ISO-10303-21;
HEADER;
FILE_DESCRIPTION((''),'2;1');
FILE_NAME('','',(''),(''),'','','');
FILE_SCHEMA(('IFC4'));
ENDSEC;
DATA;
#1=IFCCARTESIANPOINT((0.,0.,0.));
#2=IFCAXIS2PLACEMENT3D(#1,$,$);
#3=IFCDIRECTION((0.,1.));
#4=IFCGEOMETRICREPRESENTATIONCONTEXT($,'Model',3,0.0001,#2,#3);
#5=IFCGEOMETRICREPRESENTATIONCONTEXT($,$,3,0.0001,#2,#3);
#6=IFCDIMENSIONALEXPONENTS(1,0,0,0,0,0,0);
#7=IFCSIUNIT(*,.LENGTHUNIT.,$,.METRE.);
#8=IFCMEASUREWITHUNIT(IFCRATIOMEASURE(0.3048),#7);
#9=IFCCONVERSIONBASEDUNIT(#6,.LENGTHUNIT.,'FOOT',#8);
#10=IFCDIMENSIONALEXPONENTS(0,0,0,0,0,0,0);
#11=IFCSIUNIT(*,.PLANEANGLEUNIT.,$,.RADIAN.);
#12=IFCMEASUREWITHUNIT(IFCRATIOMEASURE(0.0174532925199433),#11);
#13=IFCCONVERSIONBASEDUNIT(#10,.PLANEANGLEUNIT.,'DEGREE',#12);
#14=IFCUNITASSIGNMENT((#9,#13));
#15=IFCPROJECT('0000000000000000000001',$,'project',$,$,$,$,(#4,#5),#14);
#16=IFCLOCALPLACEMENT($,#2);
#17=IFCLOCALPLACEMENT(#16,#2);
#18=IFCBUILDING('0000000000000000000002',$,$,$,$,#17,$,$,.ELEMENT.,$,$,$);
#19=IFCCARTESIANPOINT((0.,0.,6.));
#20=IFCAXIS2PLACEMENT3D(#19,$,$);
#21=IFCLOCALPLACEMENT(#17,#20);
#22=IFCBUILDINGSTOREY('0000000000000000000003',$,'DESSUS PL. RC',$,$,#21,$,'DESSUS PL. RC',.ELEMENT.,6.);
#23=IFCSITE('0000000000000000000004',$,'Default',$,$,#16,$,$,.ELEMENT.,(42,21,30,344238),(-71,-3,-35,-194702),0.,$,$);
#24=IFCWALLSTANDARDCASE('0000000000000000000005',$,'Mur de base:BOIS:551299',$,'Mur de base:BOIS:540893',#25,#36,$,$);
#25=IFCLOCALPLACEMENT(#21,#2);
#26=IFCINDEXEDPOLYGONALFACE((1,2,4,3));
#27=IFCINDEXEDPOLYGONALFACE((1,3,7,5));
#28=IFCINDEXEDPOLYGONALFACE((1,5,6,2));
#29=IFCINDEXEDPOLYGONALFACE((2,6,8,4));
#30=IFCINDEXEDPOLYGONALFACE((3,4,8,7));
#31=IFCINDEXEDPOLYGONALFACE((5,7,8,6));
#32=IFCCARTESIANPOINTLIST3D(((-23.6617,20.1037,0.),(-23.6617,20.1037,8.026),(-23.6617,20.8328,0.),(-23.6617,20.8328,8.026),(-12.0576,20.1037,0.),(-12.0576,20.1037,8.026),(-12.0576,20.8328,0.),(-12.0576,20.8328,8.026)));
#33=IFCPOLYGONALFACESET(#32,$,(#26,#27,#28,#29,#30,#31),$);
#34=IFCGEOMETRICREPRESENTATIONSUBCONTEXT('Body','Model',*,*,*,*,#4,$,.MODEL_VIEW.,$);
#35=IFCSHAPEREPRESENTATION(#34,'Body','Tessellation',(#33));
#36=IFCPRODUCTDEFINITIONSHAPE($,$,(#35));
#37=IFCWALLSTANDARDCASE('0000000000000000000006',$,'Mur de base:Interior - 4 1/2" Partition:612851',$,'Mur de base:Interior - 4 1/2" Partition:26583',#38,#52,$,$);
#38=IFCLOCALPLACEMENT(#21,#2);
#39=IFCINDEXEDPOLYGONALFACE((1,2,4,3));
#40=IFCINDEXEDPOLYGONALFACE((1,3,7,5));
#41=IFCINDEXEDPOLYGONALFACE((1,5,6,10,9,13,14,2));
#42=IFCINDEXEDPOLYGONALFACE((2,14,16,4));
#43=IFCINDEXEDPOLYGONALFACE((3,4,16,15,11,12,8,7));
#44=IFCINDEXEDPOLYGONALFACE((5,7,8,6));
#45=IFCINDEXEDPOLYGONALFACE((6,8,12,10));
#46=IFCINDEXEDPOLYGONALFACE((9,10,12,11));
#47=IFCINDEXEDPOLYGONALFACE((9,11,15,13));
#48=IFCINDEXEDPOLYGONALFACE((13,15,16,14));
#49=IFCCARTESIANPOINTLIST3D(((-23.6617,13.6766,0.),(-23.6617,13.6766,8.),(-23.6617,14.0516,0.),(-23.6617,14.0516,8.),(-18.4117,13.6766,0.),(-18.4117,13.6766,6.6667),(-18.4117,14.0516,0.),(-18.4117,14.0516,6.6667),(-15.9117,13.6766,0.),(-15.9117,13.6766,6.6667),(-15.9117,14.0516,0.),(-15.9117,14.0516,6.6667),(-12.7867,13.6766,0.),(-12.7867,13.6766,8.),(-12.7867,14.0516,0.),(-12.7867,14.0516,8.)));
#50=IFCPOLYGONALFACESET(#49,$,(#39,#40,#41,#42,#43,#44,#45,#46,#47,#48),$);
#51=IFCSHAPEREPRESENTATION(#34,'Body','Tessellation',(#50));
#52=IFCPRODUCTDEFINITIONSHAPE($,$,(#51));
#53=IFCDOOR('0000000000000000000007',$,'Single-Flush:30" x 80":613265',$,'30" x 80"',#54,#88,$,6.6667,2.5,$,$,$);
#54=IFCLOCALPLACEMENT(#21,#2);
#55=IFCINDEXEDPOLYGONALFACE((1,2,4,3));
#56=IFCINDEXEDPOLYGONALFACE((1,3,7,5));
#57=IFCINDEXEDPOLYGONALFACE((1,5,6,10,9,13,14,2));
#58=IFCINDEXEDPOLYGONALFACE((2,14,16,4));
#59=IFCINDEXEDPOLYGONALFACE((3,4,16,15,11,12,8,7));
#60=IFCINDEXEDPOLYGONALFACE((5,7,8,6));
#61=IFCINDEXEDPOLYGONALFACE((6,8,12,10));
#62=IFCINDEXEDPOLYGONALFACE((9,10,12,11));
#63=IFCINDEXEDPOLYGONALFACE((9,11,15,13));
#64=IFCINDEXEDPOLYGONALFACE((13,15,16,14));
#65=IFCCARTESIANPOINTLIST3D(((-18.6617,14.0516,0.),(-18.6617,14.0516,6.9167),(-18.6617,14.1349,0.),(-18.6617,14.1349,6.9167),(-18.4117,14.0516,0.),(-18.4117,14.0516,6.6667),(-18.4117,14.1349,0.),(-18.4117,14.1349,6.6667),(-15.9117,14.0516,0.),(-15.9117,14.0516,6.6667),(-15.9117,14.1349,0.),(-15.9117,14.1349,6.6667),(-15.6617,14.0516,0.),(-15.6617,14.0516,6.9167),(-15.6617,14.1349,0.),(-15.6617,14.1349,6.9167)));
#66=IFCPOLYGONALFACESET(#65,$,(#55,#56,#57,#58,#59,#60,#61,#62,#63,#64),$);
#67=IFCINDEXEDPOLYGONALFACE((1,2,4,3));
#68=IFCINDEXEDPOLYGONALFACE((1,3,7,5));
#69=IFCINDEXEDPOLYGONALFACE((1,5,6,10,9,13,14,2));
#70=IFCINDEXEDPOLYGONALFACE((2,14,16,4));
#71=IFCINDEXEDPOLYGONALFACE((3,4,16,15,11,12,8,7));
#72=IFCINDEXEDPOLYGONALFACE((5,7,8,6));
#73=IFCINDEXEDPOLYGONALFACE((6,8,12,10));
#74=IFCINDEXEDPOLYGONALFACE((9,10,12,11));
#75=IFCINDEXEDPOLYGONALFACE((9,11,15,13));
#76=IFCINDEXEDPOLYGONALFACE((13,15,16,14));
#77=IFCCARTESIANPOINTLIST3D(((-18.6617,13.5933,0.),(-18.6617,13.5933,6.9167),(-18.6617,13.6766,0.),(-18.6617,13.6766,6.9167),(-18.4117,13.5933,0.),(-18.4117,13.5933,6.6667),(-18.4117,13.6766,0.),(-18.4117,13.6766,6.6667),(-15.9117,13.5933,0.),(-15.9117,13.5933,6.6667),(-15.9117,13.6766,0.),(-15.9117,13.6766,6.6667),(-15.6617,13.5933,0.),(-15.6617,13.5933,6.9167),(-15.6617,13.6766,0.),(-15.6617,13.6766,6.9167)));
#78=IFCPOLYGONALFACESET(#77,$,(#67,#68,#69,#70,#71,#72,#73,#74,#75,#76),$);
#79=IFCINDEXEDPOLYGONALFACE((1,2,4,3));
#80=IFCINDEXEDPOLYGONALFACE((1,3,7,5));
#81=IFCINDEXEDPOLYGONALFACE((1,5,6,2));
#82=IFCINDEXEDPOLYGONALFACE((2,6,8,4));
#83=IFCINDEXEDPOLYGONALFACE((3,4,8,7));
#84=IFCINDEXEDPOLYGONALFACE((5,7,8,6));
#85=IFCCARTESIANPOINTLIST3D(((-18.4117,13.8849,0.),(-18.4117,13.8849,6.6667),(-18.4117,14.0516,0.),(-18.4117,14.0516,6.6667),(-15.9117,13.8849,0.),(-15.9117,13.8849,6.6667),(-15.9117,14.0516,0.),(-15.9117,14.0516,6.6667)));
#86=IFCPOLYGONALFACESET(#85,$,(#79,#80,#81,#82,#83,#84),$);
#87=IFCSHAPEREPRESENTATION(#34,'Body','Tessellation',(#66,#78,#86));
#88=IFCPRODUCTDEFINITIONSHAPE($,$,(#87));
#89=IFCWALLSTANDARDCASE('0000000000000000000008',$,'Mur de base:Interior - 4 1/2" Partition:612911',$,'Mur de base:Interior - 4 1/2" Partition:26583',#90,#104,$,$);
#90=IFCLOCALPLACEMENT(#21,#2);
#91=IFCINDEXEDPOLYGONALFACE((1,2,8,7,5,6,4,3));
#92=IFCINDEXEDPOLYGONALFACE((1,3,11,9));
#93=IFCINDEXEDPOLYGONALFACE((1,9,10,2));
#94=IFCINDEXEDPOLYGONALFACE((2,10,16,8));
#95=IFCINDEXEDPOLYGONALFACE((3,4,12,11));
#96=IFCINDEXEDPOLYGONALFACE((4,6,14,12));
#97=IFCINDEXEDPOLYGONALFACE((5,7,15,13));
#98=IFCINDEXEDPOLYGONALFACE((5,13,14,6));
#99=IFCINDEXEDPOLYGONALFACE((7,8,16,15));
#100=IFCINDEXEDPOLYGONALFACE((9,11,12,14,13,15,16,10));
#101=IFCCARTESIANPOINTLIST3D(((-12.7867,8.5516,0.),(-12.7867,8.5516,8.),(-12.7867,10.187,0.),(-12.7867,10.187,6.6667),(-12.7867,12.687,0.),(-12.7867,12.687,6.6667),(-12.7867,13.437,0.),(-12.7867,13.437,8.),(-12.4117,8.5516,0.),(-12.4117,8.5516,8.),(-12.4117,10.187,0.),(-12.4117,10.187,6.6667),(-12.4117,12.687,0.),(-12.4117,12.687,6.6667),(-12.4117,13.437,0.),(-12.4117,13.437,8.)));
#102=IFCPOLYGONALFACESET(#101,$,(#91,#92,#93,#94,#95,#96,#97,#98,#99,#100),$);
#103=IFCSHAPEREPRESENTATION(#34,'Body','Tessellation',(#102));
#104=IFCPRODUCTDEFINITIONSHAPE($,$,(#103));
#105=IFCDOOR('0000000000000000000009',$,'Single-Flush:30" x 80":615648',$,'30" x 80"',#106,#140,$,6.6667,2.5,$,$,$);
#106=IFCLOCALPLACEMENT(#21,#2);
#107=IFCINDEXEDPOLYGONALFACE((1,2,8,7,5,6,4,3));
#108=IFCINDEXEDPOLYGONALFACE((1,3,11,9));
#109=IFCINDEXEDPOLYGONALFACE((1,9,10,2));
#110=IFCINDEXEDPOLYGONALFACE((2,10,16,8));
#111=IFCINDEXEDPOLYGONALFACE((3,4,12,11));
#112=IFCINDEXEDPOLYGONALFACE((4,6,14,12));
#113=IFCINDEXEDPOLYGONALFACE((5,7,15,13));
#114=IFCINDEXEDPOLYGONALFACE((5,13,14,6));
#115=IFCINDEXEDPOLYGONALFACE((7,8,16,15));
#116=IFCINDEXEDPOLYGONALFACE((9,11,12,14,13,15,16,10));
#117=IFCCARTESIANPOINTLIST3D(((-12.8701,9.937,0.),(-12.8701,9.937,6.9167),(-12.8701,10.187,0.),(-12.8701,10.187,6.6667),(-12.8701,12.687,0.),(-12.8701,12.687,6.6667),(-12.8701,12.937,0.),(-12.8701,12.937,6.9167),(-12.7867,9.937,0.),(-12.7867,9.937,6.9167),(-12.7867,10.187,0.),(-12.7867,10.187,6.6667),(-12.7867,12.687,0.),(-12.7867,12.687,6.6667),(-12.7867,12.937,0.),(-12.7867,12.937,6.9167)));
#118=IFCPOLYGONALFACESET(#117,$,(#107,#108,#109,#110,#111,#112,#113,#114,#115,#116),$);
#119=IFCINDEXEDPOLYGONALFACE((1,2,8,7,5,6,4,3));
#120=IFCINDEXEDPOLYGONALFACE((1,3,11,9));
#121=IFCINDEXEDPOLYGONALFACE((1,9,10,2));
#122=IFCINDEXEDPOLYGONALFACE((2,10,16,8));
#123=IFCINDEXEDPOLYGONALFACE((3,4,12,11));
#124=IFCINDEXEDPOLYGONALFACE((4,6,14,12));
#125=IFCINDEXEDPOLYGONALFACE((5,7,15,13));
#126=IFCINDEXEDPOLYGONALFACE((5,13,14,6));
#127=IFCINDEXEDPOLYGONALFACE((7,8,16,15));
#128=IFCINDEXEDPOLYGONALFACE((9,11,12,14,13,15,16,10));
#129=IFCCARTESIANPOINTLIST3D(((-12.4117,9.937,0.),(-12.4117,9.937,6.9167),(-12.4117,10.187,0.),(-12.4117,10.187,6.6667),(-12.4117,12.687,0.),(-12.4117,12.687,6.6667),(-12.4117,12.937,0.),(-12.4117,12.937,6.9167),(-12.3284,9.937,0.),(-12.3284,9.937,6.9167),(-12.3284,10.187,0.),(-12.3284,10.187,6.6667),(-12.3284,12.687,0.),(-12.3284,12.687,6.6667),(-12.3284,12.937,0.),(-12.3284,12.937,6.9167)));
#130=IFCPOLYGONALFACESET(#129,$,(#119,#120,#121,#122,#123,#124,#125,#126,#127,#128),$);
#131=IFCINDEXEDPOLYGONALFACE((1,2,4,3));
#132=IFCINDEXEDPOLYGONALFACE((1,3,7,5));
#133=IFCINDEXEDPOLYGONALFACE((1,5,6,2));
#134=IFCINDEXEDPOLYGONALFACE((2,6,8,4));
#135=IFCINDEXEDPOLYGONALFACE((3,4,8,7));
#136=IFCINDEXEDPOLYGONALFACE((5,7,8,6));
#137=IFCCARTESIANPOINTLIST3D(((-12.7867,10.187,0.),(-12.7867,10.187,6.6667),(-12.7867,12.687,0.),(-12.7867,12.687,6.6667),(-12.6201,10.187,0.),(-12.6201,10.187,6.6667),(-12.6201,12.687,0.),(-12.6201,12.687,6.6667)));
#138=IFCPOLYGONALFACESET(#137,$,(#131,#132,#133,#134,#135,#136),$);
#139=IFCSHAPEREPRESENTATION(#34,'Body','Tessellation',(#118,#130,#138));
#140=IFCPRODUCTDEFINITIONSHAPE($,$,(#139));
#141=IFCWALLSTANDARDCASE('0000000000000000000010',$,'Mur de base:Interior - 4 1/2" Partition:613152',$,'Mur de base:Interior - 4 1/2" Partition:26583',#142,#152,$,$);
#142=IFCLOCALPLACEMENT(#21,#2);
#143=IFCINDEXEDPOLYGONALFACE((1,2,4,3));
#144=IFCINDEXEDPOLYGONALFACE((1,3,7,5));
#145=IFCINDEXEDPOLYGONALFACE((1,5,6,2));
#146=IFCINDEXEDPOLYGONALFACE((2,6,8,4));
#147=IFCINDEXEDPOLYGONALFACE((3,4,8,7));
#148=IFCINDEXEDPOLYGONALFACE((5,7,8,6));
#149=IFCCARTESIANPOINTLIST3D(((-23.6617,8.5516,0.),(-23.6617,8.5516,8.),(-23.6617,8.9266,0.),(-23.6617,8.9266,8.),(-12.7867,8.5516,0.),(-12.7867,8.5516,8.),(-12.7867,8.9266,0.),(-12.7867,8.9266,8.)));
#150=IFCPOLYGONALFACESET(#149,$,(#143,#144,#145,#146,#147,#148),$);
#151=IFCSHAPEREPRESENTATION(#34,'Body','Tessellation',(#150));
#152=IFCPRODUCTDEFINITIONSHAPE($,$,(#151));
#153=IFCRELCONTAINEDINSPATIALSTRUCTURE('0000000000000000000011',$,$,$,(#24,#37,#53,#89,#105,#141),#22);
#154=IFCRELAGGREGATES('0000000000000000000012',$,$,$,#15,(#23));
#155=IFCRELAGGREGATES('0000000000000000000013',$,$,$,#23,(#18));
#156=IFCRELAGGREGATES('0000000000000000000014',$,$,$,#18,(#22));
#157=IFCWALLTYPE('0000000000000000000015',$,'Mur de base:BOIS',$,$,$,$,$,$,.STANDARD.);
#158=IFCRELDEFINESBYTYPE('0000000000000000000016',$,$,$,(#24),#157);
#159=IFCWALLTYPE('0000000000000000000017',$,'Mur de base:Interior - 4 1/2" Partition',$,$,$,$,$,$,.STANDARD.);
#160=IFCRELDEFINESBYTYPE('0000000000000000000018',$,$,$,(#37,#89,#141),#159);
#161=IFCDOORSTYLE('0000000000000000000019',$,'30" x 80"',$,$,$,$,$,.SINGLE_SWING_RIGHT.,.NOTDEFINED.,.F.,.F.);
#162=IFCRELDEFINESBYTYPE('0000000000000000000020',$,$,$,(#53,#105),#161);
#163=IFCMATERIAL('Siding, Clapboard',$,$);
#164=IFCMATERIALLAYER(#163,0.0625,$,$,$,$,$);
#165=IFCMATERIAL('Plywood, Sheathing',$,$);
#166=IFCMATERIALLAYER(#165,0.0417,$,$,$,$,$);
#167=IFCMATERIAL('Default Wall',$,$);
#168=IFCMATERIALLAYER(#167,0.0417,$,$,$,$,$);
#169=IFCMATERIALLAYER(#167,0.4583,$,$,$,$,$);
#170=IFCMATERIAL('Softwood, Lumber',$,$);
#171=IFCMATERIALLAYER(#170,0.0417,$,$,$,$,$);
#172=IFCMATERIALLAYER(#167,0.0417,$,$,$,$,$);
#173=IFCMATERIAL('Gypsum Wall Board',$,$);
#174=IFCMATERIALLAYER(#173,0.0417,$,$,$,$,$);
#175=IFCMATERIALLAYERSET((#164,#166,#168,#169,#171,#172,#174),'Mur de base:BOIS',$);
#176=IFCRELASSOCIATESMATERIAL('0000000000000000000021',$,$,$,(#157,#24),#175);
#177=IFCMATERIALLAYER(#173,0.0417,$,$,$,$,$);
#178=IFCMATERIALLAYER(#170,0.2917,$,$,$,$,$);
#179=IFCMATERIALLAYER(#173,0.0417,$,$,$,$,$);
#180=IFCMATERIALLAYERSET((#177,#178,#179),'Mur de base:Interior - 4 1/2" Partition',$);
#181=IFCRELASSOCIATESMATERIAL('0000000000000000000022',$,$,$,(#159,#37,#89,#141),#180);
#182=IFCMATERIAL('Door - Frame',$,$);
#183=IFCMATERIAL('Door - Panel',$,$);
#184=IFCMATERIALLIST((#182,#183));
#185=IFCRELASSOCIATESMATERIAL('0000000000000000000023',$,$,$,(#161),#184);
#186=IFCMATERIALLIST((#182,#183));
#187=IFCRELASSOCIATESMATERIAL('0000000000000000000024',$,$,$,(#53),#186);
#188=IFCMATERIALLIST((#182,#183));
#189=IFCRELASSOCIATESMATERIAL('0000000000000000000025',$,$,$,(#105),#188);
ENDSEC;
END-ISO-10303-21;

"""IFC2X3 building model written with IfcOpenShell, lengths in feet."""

from ifc_helpers import new_model, entity, si_unit, converted_unit, direction, frame, frame_2d, origin, place, context, subcontext, project, spatial, polyline, rectangle, outline, extrude, source, transform, mapped, material, material_list, layer, layer_set, layer_usage, type_object, type_shapes, element, fill, save


model = new_model("IFC2X3")

# Units and contexts
model_context = context("Model", 3, precision=0.0001, world=origin(), true_north=direction((0.0, 1.0)))
context_of_model = context(None, 3, precision=0.0001, world=origin(), true_north=direction((0.0, 1.0)))
body_context = subcontext(model_context, "Body", "Model", "MODEL_VIEW")
ifc_project = project(units=[converted_unit("LENGTHUNIT", "FOOT", entity("IfcRatioMeasure", 0.3048), si_unit("LENGTHUNIT", "METRE"), dimensions=[1, 0, 0, 0, 0, 0, 0]), converted_unit("PLANEANGLEUNIT", "DEGREE", entity("IfcRatioMeasure", 0.0174532925199433), si_unit("PLANEANGLEUNIT", "RADIAN"), dimensions=[0, 0, 0, 0, 0, 0, 0])], contexts=[model_context, context_of_model])

# Site, building, storey
site_placement = place(None, origin())
site = spatial("IfcSite", under=ifc_project, at=site_placement, Name="Default", CompositionType="ELEMENT", RefLatitude=(42, 21, 30, 344238), RefLongitude=(-71, -3, -35, -194702), RefElevation=0.0)
building_placement = place(site_placement, origin())
building = spatial("IfcBuilding", under=site, at=building_placement, CompositionType="ELEMENT")
storey_placement = place(building_placement, frame((0.0, 0.0, 6.0)))
storey = spatial("IfcBuildingStorey", under=building, at=storey_placement, Name="DESSUS PL. RC", LongName="DESSUS PL. RC", CompositionType="ELEMENT", Elevation=6.0)

# Wall
ifc_material_1 = material(Name="Siding, Clapboard")
ifc_layer_1 = layer(ifc_material_1, 0.0625)
ifc_material_2 = material(Name="Plywood, Sheathing")
ifc_layer_2 = layer(ifc_material_2, 0.0417)
ifc_material_3 = material(Name="Default Wall")
ifc_layer_3 = layer(ifc_material_3, 0.0417)
ifc_layer_4 = layer(ifc_material_3, 0.4583)
ifc_material_4 = material(Name="Softwood, Lumber")
ifc_layer_5 = layer(ifc_material_4, 0.0417)
ifc_layer_6 = layer(ifc_material_3, 0.0417)
ifc_material_5 = material(Name="Gypsum Wall Board")
ifc_layer_7 = layer(ifc_material_5, 0.0417)
ifc_layer_set_1 = layer_set([ifc_layer_1, ifc_layer_2, ifc_layer_3, ifc_layer_4, ifc_layer_5, ifc_layer_6, ifc_layer_7], Name="Mur de base:BOIS")
ifc_layer_usage_1 = layer_usage(ifc_layer_set_1, "AXIS2", "NEGATIVE", 0.3646)
wall_type_1 = type_object("IfcWallType", Name="Mur de base:BOIS", PredefinedType="STANDARD", material=ifc_layer_set_1)
wall_1_placement = place(storey_placement, frame((-23.6617, 20.4683, 0.0)))
element("IfcWallStandardCase", 1, at=wall_1_placement, inside=storey, type_object=wall_type_1, material=ifc_layer_usage_1, Name="Mur de base:BOIS:551299", ObjectType="Mur de base:BOIS:540893", context=body_context, shape_type="SweptSolid", body=[
    extrude(rectangle(XDim=11.6042, YDim=0.7292, at=frame_2d((5.8021, 0.0), x_axis=(-1.0, 0.0))), origin(), (0.0, 0.0, 1.0), 8.026),
])

# Walls, openings, doors
ifc_layer_8 = layer(ifc_material_5, 0.0417)
ifc_layer_9 = layer(ifc_material_4, 0.2917)
ifc_layer_10 = layer(ifc_material_5, 0.0417)
ifc_layer_set_2 = layer_set([ifc_layer_8, ifc_layer_9, ifc_layer_10], Name="Mur de base:Interior - 4 1/2\" Partition")
ifc_layer_usage_2 = layer_usage(ifc_layer_set_2, "AXIS2", "NEGATIVE", 0.1875)
wall_type_2 = type_object("IfcWallType", Name="Mur de base:Interior - 4 1/2\" Partition", PredefinedType="STANDARD", material=ifc_layer_set_2)
wall_2_placement = place(storey_placement, frame((-12.7867, 13.8641, 0.0), z_axis=(0.0, 0.0, 1.0), x_axis=(-1.0, 0.0, 0.0)))
wall_2 = element("IfcWallStandardCase", 2, at=wall_2_placement, inside=storey, type_object=wall_type_2, material=ifc_layer_usage_2, Name="Mur de base:Interior - 4 1/2\" Partition:612851", ObjectType="Mur de base:Interior - 4 1/2\" Partition:26583", context=body_context, shape_type="SweptSolid", body=[
    extrude(rectangle(XDim=10.875, YDim=0.375, at=frame_2d((5.4375, 0.0), x_axis=(-1.0, 0.0))), origin(), (0.0, 0.0, 1.0), 8.0),
])
opening_1_placement = place(wall_2_placement, frame((5.625, 0.1875, 0.0)))
opening_1 = element("IfcOpeningElement", 3, at=opening_1_placement, cuts=wall_2, ObjectType="Opening", context=body_context, shape_type="SweptSolid", body=[
    extrude(rectangle(XDim=2.5, YDim=6.6667, at=frame_2d((3.3333, 1.25), x_axis=(0.0, 1.0))), frame((0.0, 0.0, 0.0), z_axis=(0.0, -1.0, 0.0), x_axis=(0.0, 0.0, 1.0)), (0.0, 0.0, 1.0), 0.375),
])
ifc_material_6 = material(Name="Door - Frame")
ifc_material_7 = material(Name="Door - Panel")
ifc_material_list_1 = material_list([ifc_material_6, ifc_material_7])
ifc_material_list_2 = material_list([ifc_material_6, ifc_material_7])
door_style_1 = type_object("IfcDoorStyle", Name="30\" x 80\"", ConstructionType="NOTDEFINED", OperationType="SINGLE_SWING_RIGHT", ParameterTakesPrecedence=False, Sizeable=False, material=ifc_material_list_2)
shared_shape_1 = source(origin(), body_context, "Body", "SweptSolid", [
    extrude(outline(polyline([(-1.5, -3.5208), (1.5, -3.5208), (1.5, 3.3958), (1.25, 3.3958), (1.25, -3.2708), (-1.25, -3.2708), (-1.25, 3.3958), (-1.5, 3.3958), (-1.5, -3.5208)])), frame((1.25, 0.375, 3.3958), z_axis=(0.0, 1.0, 0.0), x_axis=(1.0, 0.0, 0.0)), (0.0, 0.0, 1.0), 0.0833),
    extrude(outline(polyline([(-3.5208, -1.5), (3.3958, -1.5), (3.3958, -1.25), (-3.2708, -1.25), (-3.2708, 1.25), (3.3958, 1.25), (3.3958, 1.5), (-3.5208, 1.5), (-3.5208, -1.5)])), frame((1.25, -0.0833, 3.3958), z_axis=(0.0, 1.0, 0.0), x_axis=(0.0, 0.0, -1.0)), (0.0, 0.0, 1.0), 0.0833),
    extrude(rectangle(XDim=0.1667, YDim=2.5, at=frame_2d((0.0, 0.0), x_axis=(1.0, 0.0))), frame((1.25, 0.2917, 0.0), z_axis=(0.0, 0.0, 1.0), x_axis=(0.0, 1.0, 0.0)), (0.0, 0.0, 1.0), 6.6667),
])
type_shapes(door_style_1, [shared_shape_1])
door_1_placement = place(opening_1_placement, frame((0.0, 0.0, 0.0), z_axis=(0.0, 0.0, 1.0), x_axis=(-1.0, 0.0, 0.0)))
door_1 = element("IfcDoor", 4, at=door_1_placement, inside=storey, type_object=door_style_1, material=ifc_material_list_1, Name="Single-Flush:30\" x 80\":613265", ObjectType="30\" x 80\"", OverallHeight=6.6667, OverallWidth=2.5, context=body_context, shape_type="MappedRepresentation", body=[
    mapped(shared_shape_1, transform((0.0, 0.0, 0.0), scale=1.0)),
])
fill(opening_1, door_1)
ifc_layer_usage_3 = layer_usage(ifc_layer_set_2, "AXIS2", "NEGATIVE", 0.1875)
wall_3_placement = place(storey_placement, frame((-12.5992, 13.437, 0.0), z_axis=(0.0, 0.0, 1.0), x_axis=(0.0, -1.0, 0.0)))
wall_3 = element("IfcWallStandardCase", 5, at=wall_3_placement, inside=storey, type_object=wall_type_2, material=ifc_layer_usage_3, Name="Mur de base:Interior - 4 1/2\" Partition:612911", ObjectType="Mur de base:Interior - 4 1/2\" Partition:26583", context=body_context, shape_type="SweptSolid", body=[
    extrude(rectangle(XDim=4.8854, YDim=0.375, at=frame_2d((2.4427, 0.0), x_axis=(-1.0, 0.0))), origin(), (0.0, 0.0, 1.0), 8.0),
])
opening_2_placement = place(wall_3_placement, frame((3.25, 0.1875, 0.0)))
opening_2 = element("IfcOpeningElement", 6, at=opening_2_placement, cuts=wall_3, ObjectType="Opening", context=body_context, shape_type="SweptSolid", body=[
    extrude(rectangle(XDim=2.5, YDim=6.6667, at=frame_2d((3.3333, 1.25), x_axis=(0.0, 1.0))), frame((0.0, 0.0, 0.0), z_axis=(0.0, -1.0, 0.0), x_axis=(0.0, 0.0, 1.0)), (0.0, 0.0, 1.0), 0.375),
])
ifc_material_list_3 = material_list([ifc_material_6, ifc_material_7])
door_2_placement = place(opening_2_placement, frame((0.0, 0.0, 0.0), z_axis=(0.0, 0.0, 1.0), x_axis=(-1.0, 0.0, 0.0)))
door_2 = element("IfcDoor", 7, at=door_2_placement, inside=storey, type_object=door_style_1, material=ifc_material_list_3, Name="Single-Flush:30\" x 80\":615648", ObjectType="30\" x 80\"", OverallHeight=6.6667, OverallWidth=2.5, context=body_context, shape_type="MappedRepresentation", body=[
    mapped(shared_shape_1, transform((0.0, 0.0, 0.0), scale=1.0)),
])
fill(opening_2, door_2)

# Wall
ifc_layer_usage_4 = layer_usage(ifc_layer_set_2, "AXIS2", "NEGATIVE", 0.1875)
wall_4_placement = place(storey_placement, frame((-23.6617, 8.7391, 0.0)))
element("IfcWallStandardCase", 8, at=wall_4_placement, inside=storey, type_object=wall_type_2, material=ifc_layer_usage_4, Name="Mur de base:Interior - 4 1/2\" Partition:613152", ObjectType="Mur de base:Interior - 4 1/2\" Partition:26583", context=body_context, shape_type="SweptSolid", body=[
    extrude(rectangle(XDim=10.875, YDim=0.375, at=frame_2d((5.4375, 0.0), x_axis=(-1.0, 0.0))), origin(), (0.0, 0.0, 1.0), 8.0),
])

save(model, "model.ifc")
